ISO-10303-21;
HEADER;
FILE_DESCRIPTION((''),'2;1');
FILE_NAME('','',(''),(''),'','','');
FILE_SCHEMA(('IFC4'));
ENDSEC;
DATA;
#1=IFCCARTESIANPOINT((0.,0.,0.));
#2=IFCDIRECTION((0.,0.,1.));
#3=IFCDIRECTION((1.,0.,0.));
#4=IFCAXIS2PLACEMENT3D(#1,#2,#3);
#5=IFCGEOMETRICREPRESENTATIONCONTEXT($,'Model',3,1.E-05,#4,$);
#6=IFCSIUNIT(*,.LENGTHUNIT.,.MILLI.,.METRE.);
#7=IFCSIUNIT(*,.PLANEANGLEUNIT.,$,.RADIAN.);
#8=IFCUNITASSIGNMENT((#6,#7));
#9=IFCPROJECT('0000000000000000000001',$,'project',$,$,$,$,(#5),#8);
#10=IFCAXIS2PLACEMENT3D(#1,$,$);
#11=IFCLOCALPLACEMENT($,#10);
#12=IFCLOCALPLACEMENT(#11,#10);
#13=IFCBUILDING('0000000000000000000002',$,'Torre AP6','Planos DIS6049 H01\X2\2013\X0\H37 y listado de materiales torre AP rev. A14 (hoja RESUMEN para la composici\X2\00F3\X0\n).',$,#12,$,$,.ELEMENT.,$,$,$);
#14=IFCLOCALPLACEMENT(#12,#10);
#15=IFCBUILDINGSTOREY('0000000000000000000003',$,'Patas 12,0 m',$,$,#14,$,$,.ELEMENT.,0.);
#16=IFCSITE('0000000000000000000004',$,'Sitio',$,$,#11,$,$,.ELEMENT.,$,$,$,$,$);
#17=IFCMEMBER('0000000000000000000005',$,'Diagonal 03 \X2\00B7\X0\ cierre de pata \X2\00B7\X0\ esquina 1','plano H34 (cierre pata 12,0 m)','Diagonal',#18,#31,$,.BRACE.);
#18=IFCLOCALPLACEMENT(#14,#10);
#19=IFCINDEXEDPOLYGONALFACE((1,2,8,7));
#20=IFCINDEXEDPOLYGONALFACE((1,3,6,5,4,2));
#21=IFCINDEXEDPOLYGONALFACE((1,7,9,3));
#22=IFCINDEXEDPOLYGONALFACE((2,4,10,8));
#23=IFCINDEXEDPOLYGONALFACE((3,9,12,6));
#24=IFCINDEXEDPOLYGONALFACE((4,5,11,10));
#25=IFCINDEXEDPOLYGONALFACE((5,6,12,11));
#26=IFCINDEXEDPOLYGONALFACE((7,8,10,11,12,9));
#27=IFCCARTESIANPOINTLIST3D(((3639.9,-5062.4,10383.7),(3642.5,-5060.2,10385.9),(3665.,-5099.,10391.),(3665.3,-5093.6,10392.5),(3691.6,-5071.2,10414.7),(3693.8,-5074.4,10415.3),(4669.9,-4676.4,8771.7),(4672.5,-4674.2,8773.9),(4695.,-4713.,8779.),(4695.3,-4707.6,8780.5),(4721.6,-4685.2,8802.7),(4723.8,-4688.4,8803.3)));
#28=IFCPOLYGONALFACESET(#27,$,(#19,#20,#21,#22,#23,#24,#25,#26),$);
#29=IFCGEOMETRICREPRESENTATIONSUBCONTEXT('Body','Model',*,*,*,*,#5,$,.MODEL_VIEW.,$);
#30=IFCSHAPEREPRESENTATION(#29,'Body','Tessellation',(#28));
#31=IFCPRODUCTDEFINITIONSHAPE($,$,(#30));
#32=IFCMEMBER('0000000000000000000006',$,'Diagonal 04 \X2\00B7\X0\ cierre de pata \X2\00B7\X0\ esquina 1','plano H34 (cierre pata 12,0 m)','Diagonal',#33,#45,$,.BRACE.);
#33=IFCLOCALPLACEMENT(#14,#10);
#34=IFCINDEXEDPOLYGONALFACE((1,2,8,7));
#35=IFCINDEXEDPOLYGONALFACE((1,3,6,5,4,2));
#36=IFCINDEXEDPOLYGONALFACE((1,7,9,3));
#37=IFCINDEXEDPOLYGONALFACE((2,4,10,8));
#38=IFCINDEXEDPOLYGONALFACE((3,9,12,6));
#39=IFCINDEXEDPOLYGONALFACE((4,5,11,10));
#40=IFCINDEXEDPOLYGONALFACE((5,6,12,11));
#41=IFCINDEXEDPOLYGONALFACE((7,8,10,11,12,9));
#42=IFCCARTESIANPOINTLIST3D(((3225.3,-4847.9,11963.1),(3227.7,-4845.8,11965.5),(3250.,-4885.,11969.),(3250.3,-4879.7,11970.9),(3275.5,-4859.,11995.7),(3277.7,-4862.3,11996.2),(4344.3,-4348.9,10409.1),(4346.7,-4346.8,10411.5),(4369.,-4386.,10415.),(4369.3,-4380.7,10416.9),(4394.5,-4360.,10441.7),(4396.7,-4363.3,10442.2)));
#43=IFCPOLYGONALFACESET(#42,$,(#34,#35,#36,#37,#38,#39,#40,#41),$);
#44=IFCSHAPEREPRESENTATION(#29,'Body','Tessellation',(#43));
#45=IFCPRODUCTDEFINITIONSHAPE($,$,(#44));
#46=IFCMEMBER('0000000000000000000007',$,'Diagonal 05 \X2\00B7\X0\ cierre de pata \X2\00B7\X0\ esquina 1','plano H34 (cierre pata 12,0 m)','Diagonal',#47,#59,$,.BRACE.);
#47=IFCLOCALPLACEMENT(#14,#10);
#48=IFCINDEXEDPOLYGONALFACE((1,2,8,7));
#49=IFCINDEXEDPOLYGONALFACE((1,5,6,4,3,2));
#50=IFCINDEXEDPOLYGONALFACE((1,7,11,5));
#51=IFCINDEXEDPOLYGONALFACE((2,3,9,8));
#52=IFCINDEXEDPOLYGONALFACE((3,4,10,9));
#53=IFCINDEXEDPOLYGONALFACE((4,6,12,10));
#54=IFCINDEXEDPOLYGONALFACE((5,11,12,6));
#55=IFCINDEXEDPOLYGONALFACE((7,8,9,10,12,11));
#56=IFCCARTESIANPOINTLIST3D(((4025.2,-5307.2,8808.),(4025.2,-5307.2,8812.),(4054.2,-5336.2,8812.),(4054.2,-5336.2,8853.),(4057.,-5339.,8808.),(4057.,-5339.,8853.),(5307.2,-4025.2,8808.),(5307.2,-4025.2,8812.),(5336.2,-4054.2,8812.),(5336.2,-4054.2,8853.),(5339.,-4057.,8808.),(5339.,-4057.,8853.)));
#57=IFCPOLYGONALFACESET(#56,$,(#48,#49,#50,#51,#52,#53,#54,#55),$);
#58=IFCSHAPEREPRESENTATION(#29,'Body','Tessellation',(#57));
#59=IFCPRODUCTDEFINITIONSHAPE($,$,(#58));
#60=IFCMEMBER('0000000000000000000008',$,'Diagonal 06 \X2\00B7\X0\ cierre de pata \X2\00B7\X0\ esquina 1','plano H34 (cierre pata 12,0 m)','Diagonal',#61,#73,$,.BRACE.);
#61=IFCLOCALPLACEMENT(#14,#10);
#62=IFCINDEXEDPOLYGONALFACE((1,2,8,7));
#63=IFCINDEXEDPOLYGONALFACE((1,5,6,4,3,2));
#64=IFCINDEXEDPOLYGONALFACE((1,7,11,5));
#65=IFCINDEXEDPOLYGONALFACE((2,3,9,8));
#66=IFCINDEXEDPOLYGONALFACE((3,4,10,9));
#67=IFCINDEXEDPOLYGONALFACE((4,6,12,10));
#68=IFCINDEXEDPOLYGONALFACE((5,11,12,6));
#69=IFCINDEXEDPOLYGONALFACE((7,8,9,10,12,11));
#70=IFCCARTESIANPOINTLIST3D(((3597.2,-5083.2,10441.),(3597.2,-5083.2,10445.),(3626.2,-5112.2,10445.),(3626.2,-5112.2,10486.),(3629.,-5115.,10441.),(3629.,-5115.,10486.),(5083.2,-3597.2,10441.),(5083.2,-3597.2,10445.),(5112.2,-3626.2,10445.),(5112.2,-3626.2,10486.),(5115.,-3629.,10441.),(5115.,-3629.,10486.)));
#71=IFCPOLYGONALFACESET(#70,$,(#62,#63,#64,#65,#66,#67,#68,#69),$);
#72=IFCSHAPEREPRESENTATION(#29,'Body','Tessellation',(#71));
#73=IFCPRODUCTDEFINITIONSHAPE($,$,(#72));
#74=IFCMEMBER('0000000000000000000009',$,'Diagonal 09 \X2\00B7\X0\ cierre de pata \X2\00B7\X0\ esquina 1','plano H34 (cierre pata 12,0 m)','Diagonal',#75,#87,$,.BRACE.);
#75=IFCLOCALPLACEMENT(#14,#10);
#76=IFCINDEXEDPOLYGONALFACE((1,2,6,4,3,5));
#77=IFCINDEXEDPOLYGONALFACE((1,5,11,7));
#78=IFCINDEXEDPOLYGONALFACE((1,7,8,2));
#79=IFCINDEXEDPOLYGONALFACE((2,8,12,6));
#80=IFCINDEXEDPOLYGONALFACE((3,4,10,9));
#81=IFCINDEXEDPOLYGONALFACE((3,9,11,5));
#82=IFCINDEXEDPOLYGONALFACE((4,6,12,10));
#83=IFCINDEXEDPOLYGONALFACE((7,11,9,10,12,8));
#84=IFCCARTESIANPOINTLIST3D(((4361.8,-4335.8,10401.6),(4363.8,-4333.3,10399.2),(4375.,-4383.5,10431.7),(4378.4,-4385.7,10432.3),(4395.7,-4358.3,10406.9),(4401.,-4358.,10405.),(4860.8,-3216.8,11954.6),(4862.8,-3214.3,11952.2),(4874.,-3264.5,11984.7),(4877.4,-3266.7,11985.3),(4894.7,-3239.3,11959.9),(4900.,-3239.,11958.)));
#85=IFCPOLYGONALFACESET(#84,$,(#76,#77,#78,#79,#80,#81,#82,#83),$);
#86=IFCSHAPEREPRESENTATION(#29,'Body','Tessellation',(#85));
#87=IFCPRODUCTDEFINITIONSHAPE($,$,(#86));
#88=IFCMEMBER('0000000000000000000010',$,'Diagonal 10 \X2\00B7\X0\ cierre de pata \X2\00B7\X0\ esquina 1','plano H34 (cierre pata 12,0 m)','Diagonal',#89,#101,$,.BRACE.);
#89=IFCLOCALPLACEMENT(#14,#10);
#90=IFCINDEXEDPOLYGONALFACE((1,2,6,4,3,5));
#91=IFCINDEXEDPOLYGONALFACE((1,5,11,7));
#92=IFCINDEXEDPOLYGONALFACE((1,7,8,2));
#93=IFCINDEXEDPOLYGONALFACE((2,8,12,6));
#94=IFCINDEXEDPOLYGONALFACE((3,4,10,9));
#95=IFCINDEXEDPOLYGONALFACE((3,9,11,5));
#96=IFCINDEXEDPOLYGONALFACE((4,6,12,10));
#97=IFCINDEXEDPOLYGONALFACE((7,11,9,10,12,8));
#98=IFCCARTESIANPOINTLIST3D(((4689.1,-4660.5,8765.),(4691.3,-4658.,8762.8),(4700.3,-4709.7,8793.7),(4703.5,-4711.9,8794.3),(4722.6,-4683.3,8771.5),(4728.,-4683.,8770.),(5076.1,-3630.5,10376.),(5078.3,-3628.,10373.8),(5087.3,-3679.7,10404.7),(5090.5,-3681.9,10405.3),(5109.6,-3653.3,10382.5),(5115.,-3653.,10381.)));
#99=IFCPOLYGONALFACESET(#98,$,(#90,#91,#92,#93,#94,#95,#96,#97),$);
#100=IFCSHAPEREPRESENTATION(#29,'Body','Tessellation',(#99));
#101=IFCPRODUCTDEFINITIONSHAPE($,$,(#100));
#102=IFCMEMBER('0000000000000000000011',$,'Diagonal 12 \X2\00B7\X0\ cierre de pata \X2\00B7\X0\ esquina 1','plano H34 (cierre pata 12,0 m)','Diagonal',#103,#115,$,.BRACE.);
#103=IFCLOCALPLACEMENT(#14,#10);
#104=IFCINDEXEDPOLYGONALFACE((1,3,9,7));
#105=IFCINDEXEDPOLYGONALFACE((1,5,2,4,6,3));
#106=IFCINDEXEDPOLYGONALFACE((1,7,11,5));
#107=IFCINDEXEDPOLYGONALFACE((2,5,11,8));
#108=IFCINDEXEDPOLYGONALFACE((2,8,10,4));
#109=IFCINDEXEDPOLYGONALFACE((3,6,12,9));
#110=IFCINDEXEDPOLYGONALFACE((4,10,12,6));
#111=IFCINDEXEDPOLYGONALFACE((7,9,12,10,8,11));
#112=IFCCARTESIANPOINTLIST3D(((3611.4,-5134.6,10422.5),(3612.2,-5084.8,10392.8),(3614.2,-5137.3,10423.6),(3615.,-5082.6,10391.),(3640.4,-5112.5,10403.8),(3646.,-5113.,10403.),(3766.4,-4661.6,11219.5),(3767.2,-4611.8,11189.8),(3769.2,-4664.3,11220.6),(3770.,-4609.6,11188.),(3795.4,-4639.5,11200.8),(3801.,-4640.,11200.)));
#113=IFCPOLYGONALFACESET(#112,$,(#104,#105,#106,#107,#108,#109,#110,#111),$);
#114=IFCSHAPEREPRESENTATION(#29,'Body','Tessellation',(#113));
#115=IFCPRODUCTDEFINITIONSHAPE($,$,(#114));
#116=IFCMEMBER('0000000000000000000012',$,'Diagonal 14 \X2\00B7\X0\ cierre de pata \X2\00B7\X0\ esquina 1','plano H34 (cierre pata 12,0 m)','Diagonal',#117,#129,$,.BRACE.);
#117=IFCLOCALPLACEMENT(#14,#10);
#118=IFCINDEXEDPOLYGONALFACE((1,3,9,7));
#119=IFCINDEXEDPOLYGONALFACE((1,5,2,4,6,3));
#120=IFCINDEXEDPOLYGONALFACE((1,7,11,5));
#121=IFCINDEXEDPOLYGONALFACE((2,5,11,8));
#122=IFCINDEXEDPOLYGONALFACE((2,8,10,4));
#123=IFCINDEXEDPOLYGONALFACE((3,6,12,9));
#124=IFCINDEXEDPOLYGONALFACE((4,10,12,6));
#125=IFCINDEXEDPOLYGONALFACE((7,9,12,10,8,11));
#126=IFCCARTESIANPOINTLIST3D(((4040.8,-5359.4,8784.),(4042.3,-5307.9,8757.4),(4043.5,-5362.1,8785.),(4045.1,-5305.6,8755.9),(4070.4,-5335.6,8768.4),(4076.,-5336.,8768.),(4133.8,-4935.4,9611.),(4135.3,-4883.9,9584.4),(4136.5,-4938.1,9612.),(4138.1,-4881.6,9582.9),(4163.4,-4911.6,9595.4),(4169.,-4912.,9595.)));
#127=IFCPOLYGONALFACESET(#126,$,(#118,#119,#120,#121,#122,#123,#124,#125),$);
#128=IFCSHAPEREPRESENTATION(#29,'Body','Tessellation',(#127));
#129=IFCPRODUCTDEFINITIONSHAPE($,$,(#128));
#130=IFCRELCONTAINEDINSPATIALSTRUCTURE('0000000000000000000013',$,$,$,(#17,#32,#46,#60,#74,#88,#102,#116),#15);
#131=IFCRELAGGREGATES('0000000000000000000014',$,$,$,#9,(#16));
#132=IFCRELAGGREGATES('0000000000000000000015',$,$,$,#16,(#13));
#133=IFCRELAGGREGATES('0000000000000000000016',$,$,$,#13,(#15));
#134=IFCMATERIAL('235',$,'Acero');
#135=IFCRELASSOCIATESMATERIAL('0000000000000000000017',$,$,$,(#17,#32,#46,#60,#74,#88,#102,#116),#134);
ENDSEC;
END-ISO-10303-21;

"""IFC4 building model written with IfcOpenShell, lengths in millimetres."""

from ifc_helpers import new_model, si_unit, frame, frame_2d, origin, origin_with_axes, place, context, subcontext, project, spatial, l_section, extrude, material, element, save


model = new_model("IFC4")

# Units and contexts
model_context = context("Model", 3, precision=1e-05, world=origin_with_axes())
body_context = subcontext(model_context, "Body", "Model", "MODEL_VIEW")
ifc_project = project(units=[si_unit("LENGTHUNIT", "METRE", prefix="MILLI"), si_unit("PLANEANGLEUNIT", "RADIAN")], contexts=[model_context])

# Site, building, storey
site_placement = place(None, origin())
site = spatial("IfcSite", under=ifc_project, at=site_placement, Name="Sitio", CompositionType="ELEMENT")
building_placement = place(site_placement, origin())
building = spatial("IfcBuilding", under=site, at=building_placement, Name="Torre AP6", Description="Planos DIS6049 H01–H37 y listado de materiales torre AP rev. A14 (hoja RESUMEN para la composición).", CompositionType="ELEMENT")
storey_placement = place(building_placement, origin())
storey = spatial("IfcBuildingStorey", under=building, at=storey_placement, Name="Patas 12,0 m", CompositionType="ELEMENT", Elevation=0.0)

# Members
ifc_material_1 = material(Name="235", Category="Acero")
member_1_placement = place(storey_placement, frame((3665.0, -5099.0, 10391.0), z_axis=(0.527793, 0.197794, -0.826022), x_axis=(-0.557689, 0.814212, -0.161373)))
element("IfcMember", 1, at=member_1_placement, inside=storey, material=ifc_material_1, Name="Diagonal 03 · cierre de pata · esquina 1", Description="plano H34 (cierre pata 12,0 m)", ObjectType="Diagonal", PredefinedType="BRACE", context=body_context, shape_type="SweptSolid", body=[
    extrude(l_section(Depth=45.0, Width=45.0, Thickness=4.0, at=frame_2d((22.5, 22.5))), None, (0.0, 0.0, 1.0), 1951.5),
])
member_2_placement = place(storey_placement, frame((3250.0, -4885.0, 11969.0), z_axis=(0.565463, 0.252159, -0.785281), x_axis=(-0.549521, 0.82519, -0.130724)))
element("IfcMember", 2, at=member_2_placement, inside=storey, material=ifc_material_1, Name="Diagonal 04 · cierre de pata · esquina 1", Description="plano H34 (cierre pata 12,0 m)", ObjectType="Diagonal", PredefinedType="BRACE", context=body_context, shape_type="SweptSolid", body=[
    extrude(l_section(Depth=45.0, Width=45.0, Thickness=4.0, at=frame_2d((22.5, 22.5))), None, (0.0, 0.0, 1.0), 1978.9),
])
member_3_placement = place(storey_placement, frame((4057.0, -5339.0, 8808.0), z_axis=(0.707107, 0.707107, 0.0), x_axis=(-0.707107, 0.707107, 0.0)))
element("IfcMember", 3, at=member_3_placement, inside=storey, material=ifc_material_1, Name="Diagonal 05 · cierre de pata · esquina 1", Description="plano H34 (cierre pata 12,0 m)", ObjectType="Diagonal", PredefinedType="BRACE", context=body_context, shape_type="SweptSolid", body=[
    extrude(l_section(Depth=45.0, Width=45.0, Thickness=4.0, at=frame_2d((22.5, 22.5))), None, (0.0, 0.0, 1.0), 1813.0),
])
member_4_placement = place(storey_placement, frame((3629.0, -5115.0, 10441.0), z_axis=(0.707107, 0.707107, 0.0), x_axis=(-0.707107, 0.707107, 0.0)))
element("IfcMember", 4, at=member_4_placement, inside=storey, material=ifc_material_1, Name="Diagonal 06 · cierre de pata · esquina 1", Description="plano H34 (cierre pata 12,0 m)", ObjectType="Diagonal", PredefinedType="BRACE", context=body_context, shape_type="SweptSolid", body=[
    extrude(l_section(Depth=45.0, Width=45.0, Thickness=4.0, at=frame_2d((22.5, 22.5))), None, (0.0, 0.0, 1.0), 2101.5),
])
member_5_placement = place(storey_placement, frame((4401.0, -4358.0, 10405.0), z_axis=(0.252259, 0.565688, 0.785088), x_axis=(-0.826453, 0.547962, -0.129279)))
element("IfcMember", 5, at=member_5_placement, inside=storey, material=ifc_material_1, Name="Diagonal 09 · cierre de pata · esquina 1", Description="plano H34 (cierre pata 12,0 m)", ObjectType="Diagonal", PredefinedType="BRACE", context=body_context, shape_type="SweptSolid", body=[
    extrude(l_section(Depth=45.0, Width=45.0, Thickness=4.0, at=frame_2d((22.5, 22.5))), None, (0.0, 0.0, 1.0), 1978.1),
])
member_6_placement = place(storey_placement, frame((4728.0, -4683.0, 8770.0), z_axis=(0.198371, 0.527963, 0.825775), x_axis=(-0.815593, 0.556162, -0.15966)))
element("IfcMember", 6, at=member_6_placement, inside=storey, material=ifc_material_1, Name="Diagonal 10 · cierre de pata · esquina 1", Description="plano H34 (cierre pata 12,0 m)", ObjectType="Diagonal", PredefinedType="BRACE", context=body_context, shape_type="SweptSolid", body=[
    extrude(l_section(Depth=45.0, Width=45.0, Thickness=4.0, at=frame_2d((22.5, 22.5))), None, (0.0, 0.0, 1.0), 1950.9),
])
member_7_placement = place(storey_placement, frame((3646.0, -5113.0, 10403.0), z_axis=(0.164953, 0.503373, 0.848178), x_axis=(-0.688043, 0.674878, -0.266714)))
element("IfcMember", 7, at=member_7_placement, inside=storey, material=ifc_material_1, Name="Diagonal 12 · cierre de pata · esquina 1", Description="plano H34 (cierre pata 12,0 m)", ObjectType="Diagonal", PredefinedType="BRACE", context=body_context, shape_type="SweptSolid", body=[
    extrude(l_section(Depth=45.0, Width=45.0, Thickness=4.0, at=frame_2d((22.5, 22.5))), None, (0.0, 0.0, 1.0), 939.7),
])
member_8_placement = place(storey_placement, frame((4076.0, -5336.0, 8768.0), z_axis=(0.099572, 0.453962, 0.88544), x_axis=(-0.685585, 0.67623, -0.269603)))
element("IfcMember", 8, at=member_8_placement, inside=storey, material=ifc_material_1, Name="Diagonal 14 · cierre de pata · esquina 1", Description="plano H34 (cierre pata 12,0 m)", ObjectType="Diagonal", PredefinedType="BRACE", context=body_context, shape_type="SweptSolid", body=[
    extrude(l_section(Depth=45.0, Width=45.0, Thickness=4.0, at=frame_2d((22.5, 22.5))), None, (0.0, 0.0, 1.0), 934.0),
])

save(model, "model.ifc")
